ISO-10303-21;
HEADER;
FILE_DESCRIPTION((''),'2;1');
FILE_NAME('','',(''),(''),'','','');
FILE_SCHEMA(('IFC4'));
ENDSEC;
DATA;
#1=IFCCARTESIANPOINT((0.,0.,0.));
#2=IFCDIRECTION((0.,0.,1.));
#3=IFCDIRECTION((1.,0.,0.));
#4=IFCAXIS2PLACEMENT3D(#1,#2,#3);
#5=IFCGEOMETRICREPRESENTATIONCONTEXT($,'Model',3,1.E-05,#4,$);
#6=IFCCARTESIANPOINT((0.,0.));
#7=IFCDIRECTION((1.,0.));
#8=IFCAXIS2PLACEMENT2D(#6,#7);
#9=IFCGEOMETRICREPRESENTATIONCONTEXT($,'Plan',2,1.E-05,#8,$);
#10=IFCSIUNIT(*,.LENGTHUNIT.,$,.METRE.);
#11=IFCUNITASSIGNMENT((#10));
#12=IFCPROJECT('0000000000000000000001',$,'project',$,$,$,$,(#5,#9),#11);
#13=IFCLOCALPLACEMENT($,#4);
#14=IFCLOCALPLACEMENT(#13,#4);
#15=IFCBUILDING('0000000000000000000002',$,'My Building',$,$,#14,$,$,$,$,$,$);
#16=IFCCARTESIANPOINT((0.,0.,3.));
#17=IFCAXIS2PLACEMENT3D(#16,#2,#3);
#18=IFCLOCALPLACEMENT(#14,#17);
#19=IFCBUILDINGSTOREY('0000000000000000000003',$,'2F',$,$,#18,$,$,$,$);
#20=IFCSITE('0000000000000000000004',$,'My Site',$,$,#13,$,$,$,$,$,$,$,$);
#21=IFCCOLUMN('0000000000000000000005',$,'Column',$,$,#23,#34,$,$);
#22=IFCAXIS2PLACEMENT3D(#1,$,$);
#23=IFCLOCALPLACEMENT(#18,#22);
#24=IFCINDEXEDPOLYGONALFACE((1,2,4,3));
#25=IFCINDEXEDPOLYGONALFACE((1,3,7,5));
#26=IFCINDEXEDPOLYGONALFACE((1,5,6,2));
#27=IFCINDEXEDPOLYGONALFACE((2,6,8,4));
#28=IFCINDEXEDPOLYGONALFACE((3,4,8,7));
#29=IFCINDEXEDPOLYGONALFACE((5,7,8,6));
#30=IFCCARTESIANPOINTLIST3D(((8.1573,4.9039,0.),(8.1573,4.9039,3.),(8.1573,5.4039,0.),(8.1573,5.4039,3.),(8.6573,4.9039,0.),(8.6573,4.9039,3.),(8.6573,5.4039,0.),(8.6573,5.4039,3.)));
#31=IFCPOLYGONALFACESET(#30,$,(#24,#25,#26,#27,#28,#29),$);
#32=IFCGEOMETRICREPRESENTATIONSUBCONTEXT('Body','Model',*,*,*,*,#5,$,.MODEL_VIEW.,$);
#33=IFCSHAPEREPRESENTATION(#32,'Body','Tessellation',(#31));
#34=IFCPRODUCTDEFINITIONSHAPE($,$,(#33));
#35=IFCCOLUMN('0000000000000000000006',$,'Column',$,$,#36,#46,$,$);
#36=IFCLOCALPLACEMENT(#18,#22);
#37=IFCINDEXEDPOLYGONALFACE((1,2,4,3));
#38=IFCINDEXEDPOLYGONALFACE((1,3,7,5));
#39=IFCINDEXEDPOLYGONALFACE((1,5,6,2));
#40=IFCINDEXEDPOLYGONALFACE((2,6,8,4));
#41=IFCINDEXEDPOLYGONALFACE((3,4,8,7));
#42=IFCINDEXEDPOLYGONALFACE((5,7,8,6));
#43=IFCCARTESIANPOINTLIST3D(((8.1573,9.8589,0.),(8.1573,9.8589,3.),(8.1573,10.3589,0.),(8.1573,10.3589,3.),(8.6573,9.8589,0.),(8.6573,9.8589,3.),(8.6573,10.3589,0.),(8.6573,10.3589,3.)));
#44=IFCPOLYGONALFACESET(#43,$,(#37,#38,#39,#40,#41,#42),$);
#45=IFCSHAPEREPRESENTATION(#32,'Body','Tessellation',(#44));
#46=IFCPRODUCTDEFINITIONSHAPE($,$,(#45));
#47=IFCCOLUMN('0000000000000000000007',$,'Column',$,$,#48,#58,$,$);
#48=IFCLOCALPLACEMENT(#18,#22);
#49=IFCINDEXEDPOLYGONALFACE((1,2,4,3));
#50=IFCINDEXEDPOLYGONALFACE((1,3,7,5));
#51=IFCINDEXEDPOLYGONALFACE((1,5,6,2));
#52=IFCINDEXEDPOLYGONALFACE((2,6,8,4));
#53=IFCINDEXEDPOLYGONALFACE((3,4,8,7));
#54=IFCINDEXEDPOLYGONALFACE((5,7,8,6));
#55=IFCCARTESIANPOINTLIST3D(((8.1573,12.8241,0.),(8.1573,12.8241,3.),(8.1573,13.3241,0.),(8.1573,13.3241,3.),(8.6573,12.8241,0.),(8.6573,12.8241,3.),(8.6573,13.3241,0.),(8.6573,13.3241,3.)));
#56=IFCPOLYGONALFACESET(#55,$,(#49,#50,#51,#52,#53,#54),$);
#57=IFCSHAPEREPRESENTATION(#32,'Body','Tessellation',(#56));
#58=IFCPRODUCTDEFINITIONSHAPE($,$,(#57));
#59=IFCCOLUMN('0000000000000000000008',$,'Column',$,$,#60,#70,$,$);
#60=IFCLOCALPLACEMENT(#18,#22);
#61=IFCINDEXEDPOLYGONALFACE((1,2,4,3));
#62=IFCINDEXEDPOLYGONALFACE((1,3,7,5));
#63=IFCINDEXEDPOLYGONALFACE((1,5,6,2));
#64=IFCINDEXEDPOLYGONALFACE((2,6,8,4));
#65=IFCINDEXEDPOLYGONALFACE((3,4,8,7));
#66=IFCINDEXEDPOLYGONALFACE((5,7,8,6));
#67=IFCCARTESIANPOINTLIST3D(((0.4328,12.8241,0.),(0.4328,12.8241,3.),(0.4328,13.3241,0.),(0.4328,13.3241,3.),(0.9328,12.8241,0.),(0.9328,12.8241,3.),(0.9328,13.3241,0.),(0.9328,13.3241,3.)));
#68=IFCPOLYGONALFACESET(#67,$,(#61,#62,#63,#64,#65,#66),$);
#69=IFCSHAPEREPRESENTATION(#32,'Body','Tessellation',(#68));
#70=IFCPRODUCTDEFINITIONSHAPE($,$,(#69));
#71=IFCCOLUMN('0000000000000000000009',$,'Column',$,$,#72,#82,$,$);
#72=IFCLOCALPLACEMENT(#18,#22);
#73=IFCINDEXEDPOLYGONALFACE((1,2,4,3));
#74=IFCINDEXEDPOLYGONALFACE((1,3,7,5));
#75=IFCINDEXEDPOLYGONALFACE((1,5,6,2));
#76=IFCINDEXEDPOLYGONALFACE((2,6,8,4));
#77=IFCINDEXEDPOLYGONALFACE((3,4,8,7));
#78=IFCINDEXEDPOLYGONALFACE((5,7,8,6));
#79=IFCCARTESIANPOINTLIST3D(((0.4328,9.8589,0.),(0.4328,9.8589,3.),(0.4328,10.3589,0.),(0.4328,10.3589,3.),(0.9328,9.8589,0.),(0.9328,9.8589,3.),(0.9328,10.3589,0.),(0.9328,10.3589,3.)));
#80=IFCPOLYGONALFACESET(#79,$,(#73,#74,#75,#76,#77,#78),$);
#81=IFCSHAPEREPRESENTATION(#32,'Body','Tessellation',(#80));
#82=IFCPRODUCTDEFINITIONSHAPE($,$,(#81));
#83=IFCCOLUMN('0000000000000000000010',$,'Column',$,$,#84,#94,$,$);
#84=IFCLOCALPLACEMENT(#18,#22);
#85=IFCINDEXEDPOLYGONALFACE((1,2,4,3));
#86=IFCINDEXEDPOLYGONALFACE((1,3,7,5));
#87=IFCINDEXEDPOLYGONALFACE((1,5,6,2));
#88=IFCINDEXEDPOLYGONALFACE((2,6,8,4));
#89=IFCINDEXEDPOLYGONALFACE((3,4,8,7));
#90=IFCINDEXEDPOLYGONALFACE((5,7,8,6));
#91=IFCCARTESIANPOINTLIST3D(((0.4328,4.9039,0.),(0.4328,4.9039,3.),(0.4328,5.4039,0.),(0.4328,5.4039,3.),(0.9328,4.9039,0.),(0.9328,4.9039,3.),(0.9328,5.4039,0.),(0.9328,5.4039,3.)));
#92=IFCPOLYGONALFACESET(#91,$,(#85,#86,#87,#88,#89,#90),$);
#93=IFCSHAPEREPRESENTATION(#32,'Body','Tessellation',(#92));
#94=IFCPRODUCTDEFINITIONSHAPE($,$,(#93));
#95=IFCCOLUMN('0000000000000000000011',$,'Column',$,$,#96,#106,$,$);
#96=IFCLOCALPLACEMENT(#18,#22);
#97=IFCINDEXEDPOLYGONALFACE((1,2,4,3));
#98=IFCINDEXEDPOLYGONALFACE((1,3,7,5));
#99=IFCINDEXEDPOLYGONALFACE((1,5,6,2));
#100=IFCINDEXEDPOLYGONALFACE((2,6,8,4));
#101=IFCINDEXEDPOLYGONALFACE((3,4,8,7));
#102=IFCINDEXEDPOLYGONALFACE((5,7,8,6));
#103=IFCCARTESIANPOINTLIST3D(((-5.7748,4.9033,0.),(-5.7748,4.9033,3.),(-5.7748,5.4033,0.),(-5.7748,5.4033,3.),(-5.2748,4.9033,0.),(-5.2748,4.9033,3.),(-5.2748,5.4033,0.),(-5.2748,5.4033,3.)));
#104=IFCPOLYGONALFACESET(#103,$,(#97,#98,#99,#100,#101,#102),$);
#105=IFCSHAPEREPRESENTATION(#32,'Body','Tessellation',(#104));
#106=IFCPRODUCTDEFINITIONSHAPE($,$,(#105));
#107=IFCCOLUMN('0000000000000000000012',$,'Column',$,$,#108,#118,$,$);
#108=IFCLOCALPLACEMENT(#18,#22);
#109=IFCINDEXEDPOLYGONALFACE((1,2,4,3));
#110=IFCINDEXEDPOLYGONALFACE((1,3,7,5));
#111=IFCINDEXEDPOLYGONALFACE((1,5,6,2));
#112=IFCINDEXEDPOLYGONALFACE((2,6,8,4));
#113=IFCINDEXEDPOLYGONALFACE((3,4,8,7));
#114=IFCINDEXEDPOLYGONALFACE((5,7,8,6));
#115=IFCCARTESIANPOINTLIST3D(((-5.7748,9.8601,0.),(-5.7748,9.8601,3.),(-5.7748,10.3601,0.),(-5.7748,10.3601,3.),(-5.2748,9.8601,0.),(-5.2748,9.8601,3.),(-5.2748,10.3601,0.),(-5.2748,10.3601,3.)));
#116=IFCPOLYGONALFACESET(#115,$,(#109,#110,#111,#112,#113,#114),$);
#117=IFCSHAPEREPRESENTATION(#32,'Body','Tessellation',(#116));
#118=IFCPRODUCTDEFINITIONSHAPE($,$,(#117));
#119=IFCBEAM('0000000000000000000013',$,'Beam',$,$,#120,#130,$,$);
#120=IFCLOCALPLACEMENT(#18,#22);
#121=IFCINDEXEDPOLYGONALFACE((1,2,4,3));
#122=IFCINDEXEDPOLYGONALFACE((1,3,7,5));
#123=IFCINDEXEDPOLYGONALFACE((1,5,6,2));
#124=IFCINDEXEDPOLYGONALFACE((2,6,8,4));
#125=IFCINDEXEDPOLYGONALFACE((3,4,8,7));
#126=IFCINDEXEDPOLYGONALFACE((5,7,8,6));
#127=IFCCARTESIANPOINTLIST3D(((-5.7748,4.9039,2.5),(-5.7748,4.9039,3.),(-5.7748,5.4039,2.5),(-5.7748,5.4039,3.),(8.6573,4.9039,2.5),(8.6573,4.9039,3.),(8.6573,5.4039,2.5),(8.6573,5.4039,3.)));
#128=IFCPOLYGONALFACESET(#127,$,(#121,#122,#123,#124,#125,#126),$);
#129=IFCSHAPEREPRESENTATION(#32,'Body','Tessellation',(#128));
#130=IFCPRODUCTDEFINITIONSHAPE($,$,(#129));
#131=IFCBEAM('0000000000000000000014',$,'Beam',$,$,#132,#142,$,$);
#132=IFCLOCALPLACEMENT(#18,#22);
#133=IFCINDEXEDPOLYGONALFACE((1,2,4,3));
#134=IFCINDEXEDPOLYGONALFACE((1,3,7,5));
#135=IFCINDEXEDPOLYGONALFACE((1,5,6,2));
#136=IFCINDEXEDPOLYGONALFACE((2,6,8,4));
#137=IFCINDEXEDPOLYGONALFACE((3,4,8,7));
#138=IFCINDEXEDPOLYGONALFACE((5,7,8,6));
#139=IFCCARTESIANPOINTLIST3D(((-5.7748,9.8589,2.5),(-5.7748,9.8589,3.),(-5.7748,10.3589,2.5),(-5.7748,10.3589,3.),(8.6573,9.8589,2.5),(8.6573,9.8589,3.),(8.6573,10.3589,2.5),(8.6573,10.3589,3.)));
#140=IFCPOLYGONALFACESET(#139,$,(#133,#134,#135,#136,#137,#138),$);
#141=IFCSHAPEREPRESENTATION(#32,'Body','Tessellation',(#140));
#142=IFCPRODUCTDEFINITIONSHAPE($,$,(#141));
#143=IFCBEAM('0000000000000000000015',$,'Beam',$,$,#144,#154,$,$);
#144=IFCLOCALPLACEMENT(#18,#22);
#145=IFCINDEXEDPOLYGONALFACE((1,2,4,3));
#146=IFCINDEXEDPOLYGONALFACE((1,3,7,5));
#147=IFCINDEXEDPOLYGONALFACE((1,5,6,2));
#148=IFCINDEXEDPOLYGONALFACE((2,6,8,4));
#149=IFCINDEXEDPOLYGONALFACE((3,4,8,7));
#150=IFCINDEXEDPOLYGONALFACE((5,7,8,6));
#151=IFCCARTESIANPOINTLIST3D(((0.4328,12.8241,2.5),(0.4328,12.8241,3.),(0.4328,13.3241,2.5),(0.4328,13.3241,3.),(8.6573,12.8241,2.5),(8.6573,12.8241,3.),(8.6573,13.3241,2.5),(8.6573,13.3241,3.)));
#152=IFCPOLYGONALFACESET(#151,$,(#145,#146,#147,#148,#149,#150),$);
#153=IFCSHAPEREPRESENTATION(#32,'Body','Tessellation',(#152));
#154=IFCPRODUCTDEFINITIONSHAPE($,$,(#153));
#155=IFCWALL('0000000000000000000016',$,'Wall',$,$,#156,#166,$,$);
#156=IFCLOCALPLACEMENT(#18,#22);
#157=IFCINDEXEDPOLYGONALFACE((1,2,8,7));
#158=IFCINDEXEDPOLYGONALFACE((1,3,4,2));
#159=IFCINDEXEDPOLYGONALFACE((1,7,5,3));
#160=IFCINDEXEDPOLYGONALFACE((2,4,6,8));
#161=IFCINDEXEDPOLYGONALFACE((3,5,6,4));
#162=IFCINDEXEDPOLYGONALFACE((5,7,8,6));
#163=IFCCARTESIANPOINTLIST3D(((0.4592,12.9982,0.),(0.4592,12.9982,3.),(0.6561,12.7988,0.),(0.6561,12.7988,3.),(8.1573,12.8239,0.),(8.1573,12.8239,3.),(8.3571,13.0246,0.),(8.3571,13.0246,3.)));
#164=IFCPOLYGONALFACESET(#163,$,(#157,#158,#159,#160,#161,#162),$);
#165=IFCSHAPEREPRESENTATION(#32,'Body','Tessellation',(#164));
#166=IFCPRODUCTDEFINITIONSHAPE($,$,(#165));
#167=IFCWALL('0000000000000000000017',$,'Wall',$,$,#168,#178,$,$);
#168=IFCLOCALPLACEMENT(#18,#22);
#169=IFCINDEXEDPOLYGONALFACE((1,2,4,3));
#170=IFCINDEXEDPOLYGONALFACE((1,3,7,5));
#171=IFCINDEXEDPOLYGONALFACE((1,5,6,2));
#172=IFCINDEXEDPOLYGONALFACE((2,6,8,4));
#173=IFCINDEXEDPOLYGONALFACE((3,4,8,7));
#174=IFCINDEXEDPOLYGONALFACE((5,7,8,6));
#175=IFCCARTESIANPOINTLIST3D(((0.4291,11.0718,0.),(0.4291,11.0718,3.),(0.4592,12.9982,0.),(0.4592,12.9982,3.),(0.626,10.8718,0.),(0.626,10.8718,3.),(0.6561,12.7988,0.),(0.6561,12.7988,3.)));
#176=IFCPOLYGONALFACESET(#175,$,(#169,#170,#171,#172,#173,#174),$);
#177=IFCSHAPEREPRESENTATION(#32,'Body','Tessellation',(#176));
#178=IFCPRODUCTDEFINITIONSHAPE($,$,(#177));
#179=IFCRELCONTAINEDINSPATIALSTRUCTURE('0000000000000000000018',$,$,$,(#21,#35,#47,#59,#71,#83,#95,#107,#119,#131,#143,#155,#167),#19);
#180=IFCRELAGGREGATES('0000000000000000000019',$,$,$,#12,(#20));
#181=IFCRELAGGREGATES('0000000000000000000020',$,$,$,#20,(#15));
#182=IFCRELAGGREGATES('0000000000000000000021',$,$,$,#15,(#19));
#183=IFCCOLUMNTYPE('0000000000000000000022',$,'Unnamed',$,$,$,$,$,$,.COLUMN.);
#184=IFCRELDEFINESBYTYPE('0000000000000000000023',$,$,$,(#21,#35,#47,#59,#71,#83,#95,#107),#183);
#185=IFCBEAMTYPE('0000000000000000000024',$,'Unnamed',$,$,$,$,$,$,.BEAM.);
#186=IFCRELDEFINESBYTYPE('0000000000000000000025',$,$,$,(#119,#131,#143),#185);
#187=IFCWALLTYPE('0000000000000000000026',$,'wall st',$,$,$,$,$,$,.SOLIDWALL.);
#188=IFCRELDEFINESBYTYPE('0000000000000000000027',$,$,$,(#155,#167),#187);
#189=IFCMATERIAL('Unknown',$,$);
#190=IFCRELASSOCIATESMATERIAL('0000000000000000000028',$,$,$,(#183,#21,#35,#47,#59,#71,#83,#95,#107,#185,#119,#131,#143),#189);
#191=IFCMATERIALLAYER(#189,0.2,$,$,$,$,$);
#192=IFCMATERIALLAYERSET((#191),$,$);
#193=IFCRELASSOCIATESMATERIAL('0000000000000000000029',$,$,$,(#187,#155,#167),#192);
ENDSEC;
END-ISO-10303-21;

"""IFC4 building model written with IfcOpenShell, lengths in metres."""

from ifc_helpers import new_model, si_unit, frame, origin_with_axes, origin_2d_with_axis, place, context, subcontext, project, spatial, line, indexed_curve, rectangle, outline, extrude, material, layer, layer_set, layer_usage, material_profile, profile_set, profile_usage, type_object, element, save


model = new_model("IFC4")

# Units and contexts
model_context = context("Model", 3, precision=1e-05, world=origin_with_axes())
plan_context = context("Plan", 2, precision=1e-05, world=origin_2d_with_axis())
body_context_1 = subcontext(model_context, "Body", "Model", "MODEL_VIEW")
ifc_project = project(units=[si_unit("LENGTHUNIT", "METRE")], contexts=[model_context, plan_context])

# Site, building, storey
site_placement = place(None, origin_with_axes())
site = spatial("IfcSite", under=ifc_project, at=site_placement, Name="My Site")
building_placement = place(site_placement, origin_with_axes())
building = spatial("IfcBuilding", under=site, at=building_placement, Name="My Building")
storey_placement = place(building_placement, frame((0.0, 0.0, 3.0), z_axis=(0.0, 0.0, 1.0), x_axis=(1.0, 0.0, 0.0)))
storey = spatial("IfcBuildingStorey", under=building, at=storey_placement, Name="2F")

# Columns
ifc_material = material(Name="Unknown")
ifc_material_profile_1 = material_profile(ifc_material, rectangle(XDim=0.5, YDim=0.5))
ifc_profile_set_1 = profile_set([ifc_material_profile_1])
ifc_profile_usage_1 = profile_usage(ifc_profile_set_1, cardinal=1)
column_type = type_object("IfcColumnType", Name="Unnamed", PredefinedType="COLUMN", material=ifc_profile_set_1)
column_1_placement = place(storey_placement, frame((8.6573, 4.9039, 0.0), z_axis=(0.0, 0.0, 1.0), x_axis=(1.0, 0.0, 0.0)))
element("IfcColumn", 1, at=column_1_placement, inside=storey, type_object=column_type, material=ifc_profile_usage_1, Name="Column", context=body_context_1, shape_type="SweptSolid", body=[
    extrude(rectangle(XDim=0.5, YDim=0.5), frame((-0.25, 0.25, 0.0), z_axis=(0.0, 0.0, 1.0), x_axis=(1.0, 0.0, 0.0)), (0.0, 0.0, 1.0), 3.0),
])
ifc_profile_usage_2 = profile_usage(ifc_profile_set_1, cardinal=1)
column_2_placement = place(storey_placement, frame((8.6573, 9.8589, 0.0), z_axis=(0.0, 0.0, 1.0), x_axis=(1.0, 0.0, 0.0)))
element("IfcColumn", 2, at=column_2_placement, inside=storey, type_object=column_type, material=ifc_profile_usage_2, Name="Column", context=body_context_1, shape_type="SweptSolid", body=[
    extrude(rectangle(XDim=0.5, YDim=0.5), frame((-0.25, 0.25, 0.0), z_axis=(0.0, 0.0, 1.0), x_axis=(1.0, 0.0, 0.0)), (0.0, 0.0, 1.0), 3.0),
])
ifc_profile_usage_3 = profile_usage(ifc_profile_set_1, cardinal=1)
column_3_placement = place(storey_placement, frame((8.6573, 12.8241, 0.0), z_axis=(0.0, 0.0, 1.0), x_axis=(1.0, 0.0, 0.0)))
element("IfcColumn", 3, at=column_3_placement, inside=storey, type_object=column_type, material=ifc_profile_usage_3, Name="Column", context=body_context_1, shape_type="SweptSolid", body=[
    extrude(rectangle(XDim=0.5, YDim=0.5), frame((-0.25, 0.25, 0.0), z_axis=(0.0, 0.0, 1.0), x_axis=(1.0, 0.0, 0.0)), (0.0, 0.0, 1.0), 3.0),
])
ifc_profile_usage_4 = profile_usage(ifc_profile_set_1, cardinal=1)
column_4_placement = place(storey_placement, frame((0.9328, 12.8241, 0.0), z_axis=(0.0, 0.0, 1.0), x_axis=(1.0, 0.0, 0.0)))
element("IfcColumn", 4, at=column_4_placement, inside=storey, type_object=column_type, material=ifc_profile_usage_4, Name="Column", context=body_context_1, shape_type="SweptSolid", body=[
    extrude(rectangle(XDim=0.5, YDim=0.5), frame((-0.25, 0.25, 0.0), z_axis=(0.0, 0.0, 1.0), x_axis=(1.0, 0.0, 0.0)), (0.0, 0.0, 1.0), 3.0),
])
ifc_profile_usage_5 = profile_usage(ifc_profile_set_1, cardinal=1)
column_5_placement = place(storey_placement, frame((0.9328, 9.8589, 0.0), z_axis=(0.0, 0.0, 1.0), x_axis=(1.0, 0.0, 0.0)))
element("IfcColumn", 5, at=column_5_placement, inside=storey, type_object=column_type, material=ifc_profile_usage_5, Name="Column", context=body_context_1, shape_type="SweptSolid", body=[
    extrude(rectangle(XDim=0.5, YDim=0.5), frame((-0.25, 0.25, 0.0), z_axis=(0.0, 0.0, 1.0), x_axis=(1.0, 0.0, 0.0)), (0.0, 0.0, 1.0), 3.0),
])
ifc_profile_usage_6 = profile_usage(ifc_profile_set_1, cardinal=1)
column_6_placement = place(storey_placement, frame((0.9328, 4.9039, 0.0), z_axis=(0.0, 0.0, 1.0), x_axis=(1.0, 0.0, 0.0)))
element("IfcColumn", 6, at=column_6_placement, inside=storey, type_object=column_type, material=ifc_profile_usage_6, Name="Column", context=body_context_1, shape_type="SweptSolid", body=[
    extrude(rectangle(XDim=0.5, YDim=0.5), frame((-0.25, 0.25, 0.0), z_axis=(0.0, 0.0, 1.0), x_axis=(1.0, 0.0, 0.0)), (0.0, 0.0, 1.0), 3.0),
])
ifc_profile_usage_7 = profile_usage(ifc_profile_set_1, cardinal=1)
column_7_placement = place(storey_placement, frame((-5.2748, 4.9033, 0.0), z_axis=(0.0, 0.0, 1.0), x_axis=(1.0, 0.0, 0.0)))
element("IfcColumn", 7, at=column_7_placement, inside=storey, type_object=column_type, material=ifc_profile_usage_7, Name="Column", context=body_context_1, shape_type="SweptSolid", body=[
    extrude(rectangle(XDim=0.5, YDim=0.5), frame((-0.25, 0.25, 0.0), z_axis=(0.0, 0.0, 1.0), x_axis=(1.0, 0.0, 0.0)), (0.0, 0.0, 1.0), 3.0),
])
ifc_profile_usage_8 = profile_usage(ifc_profile_set_1, cardinal=1)
column_8_placement = place(storey_placement, frame((-5.2748, 9.8601, 0.0), z_axis=(0.0, 0.0, 1.0), x_axis=(1.0, 0.0, 0.0)))
element("IfcColumn", 8, at=column_8_placement, inside=storey, type_object=column_type, material=ifc_profile_usage_8, Name="Column", context=body_context_1, shape_type="SweptSolid", body=[
    extrude(rectangle(XDim=0.5, YDim=0.5), frame((-0.25, 0.25, 0.0), z_axis=(0.0, 0.0, 1.0), x_axis=(1.0, 0.0, 0.0)), (0.0, 0.0, 1.0), 3.0),
])

# Beams
ifc_material_profile_2 = material_profile(ifc_material, rectangle(XDim=0.5, YDim=0.5))
ifc_profile_set_2 = profile_set([ifc_material_profile_2])
ifc_profile_usage_9 = profile_usage(ifc_profile_set_2, cardinal=9)
beam_type = type_object("IfcBeamType", Name="Unnamed", PredefinedType="BEAM", material=ifc_profile_set_2)
beam_1_placement = place(storey_placement, frame((-5.7748, 4.9039, 3.0), z_axis=(1.0, 0.0, 0.0), x_axis=(0.0, 1.0, 0.0)))
element("IfcBeam", 9, at=beam_1_placement, inside=storey, type_object=beam_type, material=ifc_profile_usage_9, Name="Beam", context=body_context_1, shape_type="SweptSolid", body=[
    extrude(rectangle(XDim=0.5, YDim=0.5), frame((0.25, -0.25, 0.0), z_axis=(0.0, 0.0, 1.0), x_axis=(1.0, 0.0, 0.0)), (0.0, 0.0, 1.0), 14.4321),
])
ifc_profile_usage_10 = profile_usage(ifc_profile_set_2, cardinal=9)
beam_2_placement = place(storey_placement, frame((-5.7748, 9.8589, 3.0), z_axis=(1.0, 0.0, 0.0), x_axis=(0.0, 1.0, 0.0)))
element("IfcBeam", 10, at=beam_2_placement, inside=storey, type_object=beam_type, material=ifc_profile_usage_10, Name="Beam", context=body_context_1, shape_type="SweptSolid", body=[
    extrude(rectangle(XDim=0.5, YDim=0.5), frame((0.25, -0.25, 0.0), z_axis=(0.0, 0.0, 1.0), x_axis=(1.0, 0.0, 0.0)), (0.0, 0.0, 1.0), 14.4321),
])
ifc_profile_usage_11 = profile_usage(ifc_profile_set_2, cardinal=7)
beam_3_placement = place(storey_placement, frame((0.4328, 13.3241, 3.0), z_axis=(1.0, 0.0, 0.0), x_axis=(0.0, 1.0, 0.0)))
element("IfcBeam", 11, at=beam_3_placement, inside=storey, type_object=beam_type, material=ifc_profile_usage_11, Name="Beam", context=body_context_1, shape_type="SweptSolid", body=[
    extrude(rectangle(XDim=0.5, YDim=0.5), frame((-0.25, -0.25, 0.0), z_axis=(0.0, 0.0, 1.0), x_axis=(1.0, 0.0, 0.0)), (0.0, 0.0, 1.0), 8.2244),
])

# Walls
ifc_layer_1 = layer(ifc_material, 0.2)
ifc_layer_set_1 = layer_set([ifc_layer_1])
ifc_layer_usage_1 = layer_usage(ifc_layer_set_1, "AXIS2", "POSITIVE", 0.0)
wall_type_1 = type_object("IfcWallType", Name="wall st", PredefinedType="SOLIDWALL", material=ifc_layer_set_1)
wall_1_placement = place(storey_placement, frame((8.3571, 13.0246, 0.0), z_axis=(0.0, 0.0, 1.0), x_axis=(-0.999994, -0.00334, 0.0)))
element("IfcWall", 12, at=wall_1_placement, inside=storey, type_object=wall_type_1, material=ifc_layer_usage_1, Name="Wall", context=body_context_1, shape_type="SweptSolid", body=[
    extrude(outline(indexed_curve([(0.0, 0.0), (0.2005, 0.2), (7.7017, 0.2), (7.898, 0.0)], segments=[line(1, 2, 3, 4, 1)])), origin_with_axes(), (0.0, 0.0, 1.0), 3.0),
])
ifc_layer_usage_2 = layer_usage(ifc_layer_set_1, "AXIS2", "POSITIVE", 0.0)
wall_2_placement = place(storey_placement, frame((0.4592, 12.9982, 0.0), z_axis=(0.0, 0.0, 1.0), x_axis=(-0.015623, -0.999878, 0.0)))
element("IfcWall", 13, at=wall_2_placement, inside=storey, type_object=wall_type_1, material=ifc_layer_usage_2, Name="Wall", context=body_context_1, shape_type="SweptSolid", body=[
    extrude(outline(indexed_curve([(0.0, 0.0), (0.1962, 0.2), (2.1235, 0.2), (1.9266, 0.0)], segments=[line(1, 2, 3, 4, 1)])), origin_with_axes(), (0.0, 0.0, 1.0), 3.0),
])

save(model, "model.ifc")
